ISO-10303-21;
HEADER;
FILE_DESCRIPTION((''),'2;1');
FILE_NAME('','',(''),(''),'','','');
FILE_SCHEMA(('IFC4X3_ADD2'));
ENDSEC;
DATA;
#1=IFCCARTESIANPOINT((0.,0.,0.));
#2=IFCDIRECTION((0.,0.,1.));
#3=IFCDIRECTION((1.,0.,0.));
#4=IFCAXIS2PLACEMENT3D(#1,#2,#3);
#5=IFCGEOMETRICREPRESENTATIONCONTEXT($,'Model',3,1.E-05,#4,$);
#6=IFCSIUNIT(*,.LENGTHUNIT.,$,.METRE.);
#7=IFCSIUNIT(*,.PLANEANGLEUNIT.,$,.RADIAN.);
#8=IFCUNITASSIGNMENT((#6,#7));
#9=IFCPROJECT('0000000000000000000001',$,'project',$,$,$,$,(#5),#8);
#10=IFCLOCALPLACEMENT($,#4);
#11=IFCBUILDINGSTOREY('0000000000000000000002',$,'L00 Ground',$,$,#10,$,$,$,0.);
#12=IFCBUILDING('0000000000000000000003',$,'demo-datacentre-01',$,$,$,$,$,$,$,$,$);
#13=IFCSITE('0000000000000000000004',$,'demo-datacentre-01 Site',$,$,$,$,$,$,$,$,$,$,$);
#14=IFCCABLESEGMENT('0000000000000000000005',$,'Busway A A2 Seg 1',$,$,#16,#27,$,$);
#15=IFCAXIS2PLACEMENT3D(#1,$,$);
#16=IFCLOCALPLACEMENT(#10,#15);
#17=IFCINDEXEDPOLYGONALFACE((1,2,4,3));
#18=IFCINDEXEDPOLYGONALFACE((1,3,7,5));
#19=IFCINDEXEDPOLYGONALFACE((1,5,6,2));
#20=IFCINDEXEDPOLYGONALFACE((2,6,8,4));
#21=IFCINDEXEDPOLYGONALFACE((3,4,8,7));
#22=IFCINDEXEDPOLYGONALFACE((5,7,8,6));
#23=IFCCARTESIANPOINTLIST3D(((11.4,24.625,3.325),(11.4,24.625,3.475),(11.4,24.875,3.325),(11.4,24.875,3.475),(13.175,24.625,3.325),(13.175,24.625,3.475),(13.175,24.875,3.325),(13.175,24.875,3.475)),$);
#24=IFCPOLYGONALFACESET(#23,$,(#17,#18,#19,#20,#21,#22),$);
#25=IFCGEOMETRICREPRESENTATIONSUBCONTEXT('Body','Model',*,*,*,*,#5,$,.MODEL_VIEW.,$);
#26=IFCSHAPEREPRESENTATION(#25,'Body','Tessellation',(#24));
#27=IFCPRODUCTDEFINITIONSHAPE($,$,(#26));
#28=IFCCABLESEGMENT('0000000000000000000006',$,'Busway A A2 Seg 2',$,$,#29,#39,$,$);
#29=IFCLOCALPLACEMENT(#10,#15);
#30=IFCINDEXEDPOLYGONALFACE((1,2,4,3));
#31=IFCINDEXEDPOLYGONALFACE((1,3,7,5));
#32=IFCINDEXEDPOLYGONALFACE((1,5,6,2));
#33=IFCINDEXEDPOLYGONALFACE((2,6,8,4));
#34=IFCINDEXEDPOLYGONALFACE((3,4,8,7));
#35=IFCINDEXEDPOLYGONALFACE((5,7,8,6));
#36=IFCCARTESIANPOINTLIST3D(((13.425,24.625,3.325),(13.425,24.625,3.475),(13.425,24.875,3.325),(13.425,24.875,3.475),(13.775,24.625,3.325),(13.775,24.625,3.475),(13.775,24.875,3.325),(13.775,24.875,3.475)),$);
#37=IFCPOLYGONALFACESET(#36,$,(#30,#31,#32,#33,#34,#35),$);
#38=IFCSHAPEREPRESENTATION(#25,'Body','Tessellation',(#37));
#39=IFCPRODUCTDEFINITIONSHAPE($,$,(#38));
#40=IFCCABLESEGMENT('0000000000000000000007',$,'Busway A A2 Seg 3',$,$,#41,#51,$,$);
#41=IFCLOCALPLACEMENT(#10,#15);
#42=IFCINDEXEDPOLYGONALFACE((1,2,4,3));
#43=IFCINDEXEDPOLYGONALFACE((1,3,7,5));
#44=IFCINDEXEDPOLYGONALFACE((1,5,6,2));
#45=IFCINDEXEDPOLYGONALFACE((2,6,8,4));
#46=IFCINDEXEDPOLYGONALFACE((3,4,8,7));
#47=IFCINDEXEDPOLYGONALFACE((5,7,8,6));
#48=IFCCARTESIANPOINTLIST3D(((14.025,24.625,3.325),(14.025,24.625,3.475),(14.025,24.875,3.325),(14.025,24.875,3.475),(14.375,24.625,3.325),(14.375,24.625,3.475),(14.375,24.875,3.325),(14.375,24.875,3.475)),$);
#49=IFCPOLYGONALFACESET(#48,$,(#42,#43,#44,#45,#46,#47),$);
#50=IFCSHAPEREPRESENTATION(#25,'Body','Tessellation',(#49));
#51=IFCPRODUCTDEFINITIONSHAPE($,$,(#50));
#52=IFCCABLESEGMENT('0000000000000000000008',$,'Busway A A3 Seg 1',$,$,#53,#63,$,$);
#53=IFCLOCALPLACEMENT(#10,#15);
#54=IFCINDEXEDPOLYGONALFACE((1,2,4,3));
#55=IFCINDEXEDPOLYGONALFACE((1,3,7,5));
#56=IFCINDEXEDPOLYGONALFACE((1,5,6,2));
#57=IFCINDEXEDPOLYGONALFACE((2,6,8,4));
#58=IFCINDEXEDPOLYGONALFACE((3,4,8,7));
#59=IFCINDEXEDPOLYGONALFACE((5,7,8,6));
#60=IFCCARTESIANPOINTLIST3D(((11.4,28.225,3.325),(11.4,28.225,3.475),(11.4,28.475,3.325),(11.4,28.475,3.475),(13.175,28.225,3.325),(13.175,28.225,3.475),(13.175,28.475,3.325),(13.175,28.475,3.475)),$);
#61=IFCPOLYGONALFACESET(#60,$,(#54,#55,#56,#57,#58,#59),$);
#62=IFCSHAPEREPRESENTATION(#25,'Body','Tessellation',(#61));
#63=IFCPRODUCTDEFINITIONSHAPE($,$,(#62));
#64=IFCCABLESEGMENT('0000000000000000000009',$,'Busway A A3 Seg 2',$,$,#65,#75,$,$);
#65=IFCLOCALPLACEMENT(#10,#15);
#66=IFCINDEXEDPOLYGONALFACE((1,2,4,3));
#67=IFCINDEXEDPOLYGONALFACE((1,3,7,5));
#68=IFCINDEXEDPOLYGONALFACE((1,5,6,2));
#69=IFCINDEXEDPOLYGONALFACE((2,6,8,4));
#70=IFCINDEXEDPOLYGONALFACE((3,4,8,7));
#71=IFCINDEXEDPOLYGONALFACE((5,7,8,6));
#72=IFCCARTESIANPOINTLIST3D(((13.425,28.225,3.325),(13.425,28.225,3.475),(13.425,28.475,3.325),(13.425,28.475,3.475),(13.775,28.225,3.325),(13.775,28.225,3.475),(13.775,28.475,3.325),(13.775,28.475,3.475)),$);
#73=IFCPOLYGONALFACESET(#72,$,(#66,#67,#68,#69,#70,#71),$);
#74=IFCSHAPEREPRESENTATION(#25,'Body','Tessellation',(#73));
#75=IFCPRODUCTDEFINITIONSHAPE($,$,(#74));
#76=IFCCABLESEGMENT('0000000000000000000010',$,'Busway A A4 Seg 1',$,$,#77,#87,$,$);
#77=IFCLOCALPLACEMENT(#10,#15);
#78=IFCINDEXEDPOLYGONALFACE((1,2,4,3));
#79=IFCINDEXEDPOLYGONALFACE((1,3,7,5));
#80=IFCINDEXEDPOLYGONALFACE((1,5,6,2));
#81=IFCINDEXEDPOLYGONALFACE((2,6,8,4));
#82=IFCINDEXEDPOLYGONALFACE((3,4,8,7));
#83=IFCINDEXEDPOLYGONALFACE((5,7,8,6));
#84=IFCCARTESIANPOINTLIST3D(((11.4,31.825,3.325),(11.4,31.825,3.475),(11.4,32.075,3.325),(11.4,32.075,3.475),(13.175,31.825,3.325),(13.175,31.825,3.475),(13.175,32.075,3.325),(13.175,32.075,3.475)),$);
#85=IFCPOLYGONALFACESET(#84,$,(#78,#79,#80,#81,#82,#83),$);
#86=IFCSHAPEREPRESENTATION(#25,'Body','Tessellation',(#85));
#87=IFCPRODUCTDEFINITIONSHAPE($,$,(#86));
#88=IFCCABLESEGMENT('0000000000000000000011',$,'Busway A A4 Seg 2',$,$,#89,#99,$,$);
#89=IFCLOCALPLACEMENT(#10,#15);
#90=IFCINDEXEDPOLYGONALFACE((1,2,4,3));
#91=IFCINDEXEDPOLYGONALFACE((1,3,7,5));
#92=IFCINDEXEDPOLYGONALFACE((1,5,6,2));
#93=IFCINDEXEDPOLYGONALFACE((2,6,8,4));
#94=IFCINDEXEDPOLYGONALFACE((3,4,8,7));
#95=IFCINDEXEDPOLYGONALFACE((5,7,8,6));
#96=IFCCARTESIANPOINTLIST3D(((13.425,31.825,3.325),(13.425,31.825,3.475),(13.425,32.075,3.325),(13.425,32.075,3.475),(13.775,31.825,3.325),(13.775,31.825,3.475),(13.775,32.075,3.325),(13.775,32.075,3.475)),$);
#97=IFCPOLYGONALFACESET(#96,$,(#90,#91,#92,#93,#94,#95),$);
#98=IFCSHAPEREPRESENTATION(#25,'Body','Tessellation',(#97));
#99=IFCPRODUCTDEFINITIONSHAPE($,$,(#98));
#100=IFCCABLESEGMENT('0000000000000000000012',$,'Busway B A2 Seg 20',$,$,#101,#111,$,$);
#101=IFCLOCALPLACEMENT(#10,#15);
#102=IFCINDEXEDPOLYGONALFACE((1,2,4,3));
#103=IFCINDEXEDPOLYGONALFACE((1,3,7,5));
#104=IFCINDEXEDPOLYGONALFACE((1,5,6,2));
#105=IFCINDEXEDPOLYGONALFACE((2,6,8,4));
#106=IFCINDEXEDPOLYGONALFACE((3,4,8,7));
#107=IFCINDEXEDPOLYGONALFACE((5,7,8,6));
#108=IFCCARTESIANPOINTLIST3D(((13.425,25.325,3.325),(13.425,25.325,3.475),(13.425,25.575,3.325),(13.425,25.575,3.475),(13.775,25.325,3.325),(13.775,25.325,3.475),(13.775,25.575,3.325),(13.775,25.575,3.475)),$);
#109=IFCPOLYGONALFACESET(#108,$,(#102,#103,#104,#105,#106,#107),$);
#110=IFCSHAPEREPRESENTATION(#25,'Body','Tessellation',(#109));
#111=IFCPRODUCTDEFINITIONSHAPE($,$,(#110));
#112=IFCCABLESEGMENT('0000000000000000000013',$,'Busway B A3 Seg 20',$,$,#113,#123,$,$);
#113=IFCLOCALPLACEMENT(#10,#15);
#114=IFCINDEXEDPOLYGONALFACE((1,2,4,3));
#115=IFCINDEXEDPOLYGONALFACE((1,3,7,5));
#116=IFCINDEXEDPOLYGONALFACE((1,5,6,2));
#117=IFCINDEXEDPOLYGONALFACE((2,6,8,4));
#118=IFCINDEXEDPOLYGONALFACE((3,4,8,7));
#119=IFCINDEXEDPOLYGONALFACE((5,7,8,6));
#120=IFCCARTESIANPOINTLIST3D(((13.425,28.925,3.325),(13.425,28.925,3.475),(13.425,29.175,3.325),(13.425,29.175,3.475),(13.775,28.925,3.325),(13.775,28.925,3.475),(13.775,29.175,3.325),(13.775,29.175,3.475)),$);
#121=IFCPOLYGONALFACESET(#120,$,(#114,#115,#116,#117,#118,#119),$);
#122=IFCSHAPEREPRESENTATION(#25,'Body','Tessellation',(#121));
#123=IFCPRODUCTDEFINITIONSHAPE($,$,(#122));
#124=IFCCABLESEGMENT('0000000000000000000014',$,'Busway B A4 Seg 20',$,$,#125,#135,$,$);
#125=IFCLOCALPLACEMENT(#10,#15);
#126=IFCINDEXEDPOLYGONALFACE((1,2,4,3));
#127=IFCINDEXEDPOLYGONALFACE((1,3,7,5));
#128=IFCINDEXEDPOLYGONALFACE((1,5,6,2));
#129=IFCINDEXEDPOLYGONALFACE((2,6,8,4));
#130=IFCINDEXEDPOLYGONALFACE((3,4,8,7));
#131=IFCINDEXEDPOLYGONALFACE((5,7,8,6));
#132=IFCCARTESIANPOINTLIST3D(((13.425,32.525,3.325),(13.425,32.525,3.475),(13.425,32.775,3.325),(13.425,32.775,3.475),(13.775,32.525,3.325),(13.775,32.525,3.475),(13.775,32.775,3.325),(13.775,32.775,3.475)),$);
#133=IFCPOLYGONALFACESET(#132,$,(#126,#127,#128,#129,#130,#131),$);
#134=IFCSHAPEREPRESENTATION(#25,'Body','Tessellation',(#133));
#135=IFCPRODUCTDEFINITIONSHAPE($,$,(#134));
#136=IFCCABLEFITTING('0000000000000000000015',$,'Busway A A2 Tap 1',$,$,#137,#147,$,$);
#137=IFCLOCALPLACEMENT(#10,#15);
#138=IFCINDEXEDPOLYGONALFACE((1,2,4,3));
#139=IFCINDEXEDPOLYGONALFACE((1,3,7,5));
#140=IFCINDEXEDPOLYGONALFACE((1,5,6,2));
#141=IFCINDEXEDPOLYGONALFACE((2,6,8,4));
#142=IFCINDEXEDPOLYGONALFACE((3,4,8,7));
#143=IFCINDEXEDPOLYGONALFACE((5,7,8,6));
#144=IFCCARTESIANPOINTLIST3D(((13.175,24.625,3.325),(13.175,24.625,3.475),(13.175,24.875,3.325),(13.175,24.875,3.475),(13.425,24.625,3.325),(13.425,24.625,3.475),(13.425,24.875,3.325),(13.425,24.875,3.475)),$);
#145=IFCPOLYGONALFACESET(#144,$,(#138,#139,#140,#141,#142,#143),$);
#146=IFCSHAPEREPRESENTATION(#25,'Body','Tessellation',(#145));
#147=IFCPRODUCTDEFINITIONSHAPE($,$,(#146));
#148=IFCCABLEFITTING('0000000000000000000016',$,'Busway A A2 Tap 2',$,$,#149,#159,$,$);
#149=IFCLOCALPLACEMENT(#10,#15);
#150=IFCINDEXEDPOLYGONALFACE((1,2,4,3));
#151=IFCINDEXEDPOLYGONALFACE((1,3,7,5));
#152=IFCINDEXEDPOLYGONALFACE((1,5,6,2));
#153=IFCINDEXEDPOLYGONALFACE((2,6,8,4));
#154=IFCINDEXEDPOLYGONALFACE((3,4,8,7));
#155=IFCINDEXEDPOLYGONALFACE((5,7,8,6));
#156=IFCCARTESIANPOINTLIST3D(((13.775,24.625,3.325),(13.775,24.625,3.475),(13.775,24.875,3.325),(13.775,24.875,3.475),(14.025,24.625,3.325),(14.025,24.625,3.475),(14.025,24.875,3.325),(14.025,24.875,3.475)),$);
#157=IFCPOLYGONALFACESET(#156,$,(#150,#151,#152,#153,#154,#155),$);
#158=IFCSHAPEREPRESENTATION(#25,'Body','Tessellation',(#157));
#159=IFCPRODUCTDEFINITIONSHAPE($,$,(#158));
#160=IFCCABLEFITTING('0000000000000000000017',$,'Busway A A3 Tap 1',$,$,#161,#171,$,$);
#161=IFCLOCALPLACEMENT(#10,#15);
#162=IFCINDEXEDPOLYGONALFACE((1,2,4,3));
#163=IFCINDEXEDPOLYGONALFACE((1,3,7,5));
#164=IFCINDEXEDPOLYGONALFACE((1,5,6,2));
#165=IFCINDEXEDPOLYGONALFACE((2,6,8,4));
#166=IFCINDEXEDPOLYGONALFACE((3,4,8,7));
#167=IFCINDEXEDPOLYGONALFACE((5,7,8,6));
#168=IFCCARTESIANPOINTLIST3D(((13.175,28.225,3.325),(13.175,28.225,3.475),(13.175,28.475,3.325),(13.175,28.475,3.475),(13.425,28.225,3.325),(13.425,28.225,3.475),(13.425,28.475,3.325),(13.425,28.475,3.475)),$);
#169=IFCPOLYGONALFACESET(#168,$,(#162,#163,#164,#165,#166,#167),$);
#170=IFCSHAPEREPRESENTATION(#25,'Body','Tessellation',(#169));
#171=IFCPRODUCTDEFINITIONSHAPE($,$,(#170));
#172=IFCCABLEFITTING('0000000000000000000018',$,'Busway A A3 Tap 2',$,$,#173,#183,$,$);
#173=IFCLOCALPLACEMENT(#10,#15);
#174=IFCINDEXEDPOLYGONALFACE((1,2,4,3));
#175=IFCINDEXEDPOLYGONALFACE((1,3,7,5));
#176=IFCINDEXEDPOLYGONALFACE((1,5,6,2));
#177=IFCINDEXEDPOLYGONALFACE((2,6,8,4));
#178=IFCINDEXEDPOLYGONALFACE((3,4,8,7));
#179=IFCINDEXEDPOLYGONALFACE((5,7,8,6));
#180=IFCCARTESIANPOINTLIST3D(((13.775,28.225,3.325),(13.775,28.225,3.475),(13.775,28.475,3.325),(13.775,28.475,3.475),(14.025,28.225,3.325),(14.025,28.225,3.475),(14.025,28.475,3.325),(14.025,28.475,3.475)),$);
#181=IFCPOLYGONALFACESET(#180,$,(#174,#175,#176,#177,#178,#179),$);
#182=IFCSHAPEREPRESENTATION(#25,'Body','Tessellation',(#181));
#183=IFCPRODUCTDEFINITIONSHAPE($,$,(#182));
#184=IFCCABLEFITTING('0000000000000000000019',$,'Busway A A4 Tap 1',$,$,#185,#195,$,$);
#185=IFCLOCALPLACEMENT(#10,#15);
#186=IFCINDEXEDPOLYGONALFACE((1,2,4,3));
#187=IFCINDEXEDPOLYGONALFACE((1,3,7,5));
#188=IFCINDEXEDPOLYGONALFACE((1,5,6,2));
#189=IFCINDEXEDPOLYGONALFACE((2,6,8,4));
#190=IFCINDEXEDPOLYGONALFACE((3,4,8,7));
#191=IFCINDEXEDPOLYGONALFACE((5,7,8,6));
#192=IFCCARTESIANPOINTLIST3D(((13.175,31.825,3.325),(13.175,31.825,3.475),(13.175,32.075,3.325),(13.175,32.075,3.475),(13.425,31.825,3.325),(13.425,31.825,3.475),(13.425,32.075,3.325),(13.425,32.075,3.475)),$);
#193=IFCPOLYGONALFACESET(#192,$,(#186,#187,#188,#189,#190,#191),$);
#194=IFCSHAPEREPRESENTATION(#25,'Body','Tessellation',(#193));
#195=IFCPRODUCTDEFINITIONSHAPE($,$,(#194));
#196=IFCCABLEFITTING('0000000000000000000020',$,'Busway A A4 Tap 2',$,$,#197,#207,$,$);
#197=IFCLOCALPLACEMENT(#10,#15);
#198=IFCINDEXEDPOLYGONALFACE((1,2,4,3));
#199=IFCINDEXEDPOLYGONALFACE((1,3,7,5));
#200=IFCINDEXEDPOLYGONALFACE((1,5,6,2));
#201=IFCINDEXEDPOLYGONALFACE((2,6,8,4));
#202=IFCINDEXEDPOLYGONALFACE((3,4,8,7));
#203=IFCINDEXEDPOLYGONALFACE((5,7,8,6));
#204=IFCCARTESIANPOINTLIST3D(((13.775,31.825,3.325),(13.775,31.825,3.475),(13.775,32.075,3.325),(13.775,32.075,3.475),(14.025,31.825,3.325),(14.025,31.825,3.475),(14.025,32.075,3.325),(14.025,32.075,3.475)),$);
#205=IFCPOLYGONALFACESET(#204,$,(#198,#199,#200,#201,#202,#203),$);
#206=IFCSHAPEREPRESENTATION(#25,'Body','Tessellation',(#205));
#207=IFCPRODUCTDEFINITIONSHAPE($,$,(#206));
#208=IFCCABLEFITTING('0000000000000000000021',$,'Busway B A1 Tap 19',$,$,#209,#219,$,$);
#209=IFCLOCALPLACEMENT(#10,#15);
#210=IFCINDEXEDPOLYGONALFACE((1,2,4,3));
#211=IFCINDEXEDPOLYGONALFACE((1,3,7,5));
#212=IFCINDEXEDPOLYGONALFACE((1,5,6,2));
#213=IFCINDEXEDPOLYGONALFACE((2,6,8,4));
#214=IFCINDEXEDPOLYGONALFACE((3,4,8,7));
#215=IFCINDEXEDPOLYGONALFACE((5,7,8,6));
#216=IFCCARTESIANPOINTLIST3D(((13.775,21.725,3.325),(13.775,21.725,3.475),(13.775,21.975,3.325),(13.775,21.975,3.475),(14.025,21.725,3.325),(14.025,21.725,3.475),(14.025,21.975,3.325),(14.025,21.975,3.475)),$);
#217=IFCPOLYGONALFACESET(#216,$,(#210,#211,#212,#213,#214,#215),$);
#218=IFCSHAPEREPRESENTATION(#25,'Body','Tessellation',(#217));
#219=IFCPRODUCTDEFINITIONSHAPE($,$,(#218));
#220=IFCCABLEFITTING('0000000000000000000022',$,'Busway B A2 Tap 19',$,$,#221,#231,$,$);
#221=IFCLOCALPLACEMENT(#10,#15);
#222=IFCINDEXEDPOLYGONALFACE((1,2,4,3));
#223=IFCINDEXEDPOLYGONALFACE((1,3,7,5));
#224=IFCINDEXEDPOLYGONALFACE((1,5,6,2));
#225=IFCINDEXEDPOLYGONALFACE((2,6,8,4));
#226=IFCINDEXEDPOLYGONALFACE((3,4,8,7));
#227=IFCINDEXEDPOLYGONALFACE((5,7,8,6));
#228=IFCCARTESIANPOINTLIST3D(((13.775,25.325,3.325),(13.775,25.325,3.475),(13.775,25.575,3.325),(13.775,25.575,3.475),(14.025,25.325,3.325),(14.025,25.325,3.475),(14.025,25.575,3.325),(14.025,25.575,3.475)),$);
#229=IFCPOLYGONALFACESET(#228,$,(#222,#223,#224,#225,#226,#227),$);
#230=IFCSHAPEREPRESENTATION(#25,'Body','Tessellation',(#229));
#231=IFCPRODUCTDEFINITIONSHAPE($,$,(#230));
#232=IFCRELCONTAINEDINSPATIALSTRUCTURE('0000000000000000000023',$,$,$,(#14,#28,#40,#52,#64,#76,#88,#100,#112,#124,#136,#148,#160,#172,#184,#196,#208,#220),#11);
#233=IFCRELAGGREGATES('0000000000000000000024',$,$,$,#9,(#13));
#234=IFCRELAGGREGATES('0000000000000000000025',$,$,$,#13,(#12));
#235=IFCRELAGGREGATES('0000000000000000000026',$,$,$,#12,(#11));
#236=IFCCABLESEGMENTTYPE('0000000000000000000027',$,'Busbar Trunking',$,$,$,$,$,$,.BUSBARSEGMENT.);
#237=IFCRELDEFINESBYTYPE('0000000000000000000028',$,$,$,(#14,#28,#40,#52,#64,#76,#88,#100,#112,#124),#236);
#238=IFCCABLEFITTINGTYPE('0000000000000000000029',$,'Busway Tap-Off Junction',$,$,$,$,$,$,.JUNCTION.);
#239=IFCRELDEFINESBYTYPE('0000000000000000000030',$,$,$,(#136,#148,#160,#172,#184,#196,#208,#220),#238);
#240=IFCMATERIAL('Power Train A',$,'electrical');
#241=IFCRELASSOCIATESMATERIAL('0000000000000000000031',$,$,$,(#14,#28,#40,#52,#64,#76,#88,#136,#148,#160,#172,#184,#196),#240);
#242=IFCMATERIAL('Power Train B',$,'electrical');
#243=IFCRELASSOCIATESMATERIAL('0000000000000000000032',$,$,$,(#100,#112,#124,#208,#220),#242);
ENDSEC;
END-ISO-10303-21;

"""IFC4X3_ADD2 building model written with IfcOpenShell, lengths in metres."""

from ifc_helpers import new_model, si_unit, frame, origin_with_axes, place, context, subcontext, project, spatial, rectangle, extrude, material, type_object, element, save


model = new_model("IFC4X3_ADD2")

# Units and contexts
model_context = context("Model", 3, precision=1e-05, world=origin_with_axes())
body_context = subcontext(model_context, "Body", "Model", "MODEL_VIEW")
ifc_project = project(units=[si_unit("LENGTHUNIT", "METRE"), si_unit("PLANEANGLEUNIT", "RADIAN")], contexts=[model_context])

# Site, building, storey
site = spatial("IfcSite", under=ifc_project, Name="demo-datacentre-01 Site")
building = spatial("IfcBuilding", under=site, Name="demo-datacentre-01")
storey_placement = place(None, origin_with_axes())
storey = spatial("IfcBuildingStorey", under=building, at=storey_placement, Name="L00 Ground", Elevation=0.0)

# Shared definitions
ifc_material_1 = material(Name="Power Train A", Category="electrical")

# Cable segments
cable_segment_type_1 = type_object("IfcCableSegmentType", Name="Busbar Trunking", PredefinedType="BUSBARSEGMENT")
cable_segment_1_placement = place(storey_placement, frame((11.4, 24.75, 3.4), z_axis=(1.0, 0.0, 0.0), x_axis=(0.0, 1.0, 0.0)))
element("IfcCableSegment", 1, at=cable_segment_1_placement, inside=storey, type_object=cable_segment_type_1, material=ifc_material_1, Name="Busway A A2 Seg 1", context=body_context, shape_type="SweptSolid", body=[
    extrude(rectangle(XDim=0.25, YDim=0.15), origin_with_axes(), (0.0, 0.0, 1.0), 1.775),
])
for number, where, z_axis, x_axis, name in (
    (2, (13.425, 24.75, 3.4), (1.0, 0.0, 0.0), (0.0, 1.0, 0.0), "Busway A A2 Seg 2"),
    (3, (14.025, 24.75, 3.4), (1.0, 0.0, 0.0), (0.0, 1.0, 0.0), "Busway A A2 Seg 3"),
):
    element("IfcCableSegment", number, at=place(storey_placement, frame(where, z_axis=z_axis, x_axis=x_axis)), inside=storey, type_object=cable_segment_type_1, material=ifc_material_1, Name=name, context=body_context, shape_type="SweptSolid", body=[
        extrude(rectangle(XDim=0.25, YDim=0.15), origin_with_axes(), (0.0, 0.0, 1.0), 0.35),
    ])
cable_segment_2_placement = place(storey_placement, frame((11.4, 28.35, 3.4), z_axis=(1.0, 0.0, 0.0), x_axis=(0.0, 1.0, 0.0)))
element("IfcCableSegment", 4, at=cable_segment_2_placement, inside=storey, type_object=cable_segment_type_1, material=ifc_material_1, Name="Busway A A3 Seg 1", context=body_context, shape_type="SweptSolid", body=[
    extrude(rectangle(XDim=0.25, YDim=0.15), origin_with_axes(), (0.0, 0.0, 1.0), 1.775),
])
cable_segment_3_placement = place(storey_placement, frame((13.425, 28.35, 3.4), z_axis=(1.0, 0.0, 0.0), x_axis=(0.0, 1.0, 0.0)))
element("IfcCableSegment", 5, at=cable_segment_3_placement, inside=storey, type_object=cable_segment_type_1, material=ifc_material_1, Name="Busway A A3 Seg 2", context=body_context, shape_type="SweptSolid", body=[
    extrude(rectangle(XDim=0.25, YDim=0.15), origin_with_axes(), (0.0, 0.0, 1.0), 0.35),
])
cable_segment_4_placement = place(storey_placement, frame((11.4, 31.95, 3.4), z_axis=(1.0, 0.0, 0.0), x_axis=(0.0, 1.0, 0.0)))
element("IfcCableSegment", 6, at=cable_segment_4_placement, inside=storey, type_object=cable_segment_type_1, material=ifc_material_1, Name="Busway A A4 Seg 1", context=body_context, shape_type="SweptSolid", body=[
    extrude(rectangle(XDim=0.25, YDim=0.15), origin_with_axes(), (0.0, 0.0, 1.0), 1.775),
])
cable_segment_5_placement = place(storey_placement, frame((13.425, 31.95, 3.4), z_axis=(1.0, 0.0, 0.0), x_axis=(0.0, 1.0, 0.0)))
element("IfcCableSegment", 7, at=cable_segment_5_placement, inside=storey, type_object=cable_segment_type_1, material=ifc_material_1, Name="Busway A A4 Seg 2", context=body_context, shape_type="SweptSolid", body=[
    extrude(rectangle(XDim=0.25, YDim=0.15), origin_with_axes(), (0.0, 0.0, 1.0), 0.35),
])
ifc_material_2 = material(Name="Power Train B", Category="electrical")
for number, where, z_axis, x_axis, name in (
    (8, (13.775, 25.45, 3.4), (-1.0, 0.0, 0.0), (0.0, -1.0, 0.0), "Busway B A2 Seg 20"),
    (9, (13.775, 29.05, 3.4), (-1.0, 0.0, 0.0), (0.0, -1.0, 0.0), "Busway B A3 Seg 20"),
    (10, (13.775, 32.65, 3.4), (-1.0, 0.0, 0.0), (0.0, -1.0, 0.0), "Busway B A4 Seg 20"),
):
    element("IfcCableSegment", number, at=place(storey_placement, frame(where, z_axis=z_axis, x_axis=x_axis)), inside=storey, type_object=cable_segment_type_1, material=ifc_material_2, Name=name, context=body_context, shape_type="SweptSolid", body=[
        extrude(rectangle(XDim=0.25, YDim=0.15), origin_with_axes(), (0.0, 0.0, 1.0), 0.35),
    ])

# Cable fittings
cable_fitting_type = type_object("IfcCableFittingType", Name="Busway Tap-Off Junction", PredefinedType="JUNCTION")
for number, where, z_axis, x_axis, name in (
    (11, (13.3, 24.75, 3.325), (0.0, 0.0, 1.0), (1.0, 0.0, 0.0), "Busway A A2 Tap 1"),
    (12, (13.9, 24.75, 3.325), (0.0, 0.0, 1.0), (1.0, 0.0, 0.0), "Busway A A2 Tap 2"),
    (13, (13.3, 28.35, 3.325), (0.0, 0.0, 1.0), (1.0, 0.0, 0.0), "Busway A A3 Tap 1"),
    (14, (13.9, 28.35, 3.325), (0.0, 0.0, 1.0), (1.0, 0.0, 0.0), "Busway A A3 Tap 2"),
    (15, (13.3, 31.95, 3.325), (0.0, 0.0, 1.0), (1.0, 0.0, 0.0), "Busway A A4 Tap 1"),
    (16, (13.9, 31.95, 3.325), (0.0, 0.0, 1.0), (1.0, 0.0, 0.0), "Busway A A4 Tap 2"),
):
    element("IfcCableFitting", number, at=place(storey_placement, frame(where, z_axis=z_axis, x_axis=x_axis)), inside=storey, type_object=cable_fitting_type, material=ifc_material_1, Name=name, context=body_context, shape_type="SweptSolid", body=[
        extrude(rectangle(XDim=0.25, YDim=0.25), origin_with_axes(), (0.0, 0.0, 1.0), 0.15),
    ])
for number, where, z_axis, x_axis, name in (
    (17, (13.9, 21.85, 3.325), (0.0, 0.0, 1.0), (1.0, 0.0, 0.0), "Busway B A1 Tap 19"),
    (18, (13.9, 25.45, 3.325), (0.0, 0.0, 1.0), (1.0, 0.0, 0.0), "Busway B A2 Tap 19"),
):
    element("IfcCableFitting", number, at=place(storey_placement, frame(where, z_axis=z_axis, x_axis=x_axis)), inside=storey, type_object=cable_fitting_type, material=ifc_material_2, Name=name, context=body_context, shape_type="SweptSolid", body=[
        extrude(rectangle(XDim=0.25, YDim=0.25), origin_with_axes(), (0.0, 0.0, 1.0), 0.15),
    ])

save(model, "model.ifc")
